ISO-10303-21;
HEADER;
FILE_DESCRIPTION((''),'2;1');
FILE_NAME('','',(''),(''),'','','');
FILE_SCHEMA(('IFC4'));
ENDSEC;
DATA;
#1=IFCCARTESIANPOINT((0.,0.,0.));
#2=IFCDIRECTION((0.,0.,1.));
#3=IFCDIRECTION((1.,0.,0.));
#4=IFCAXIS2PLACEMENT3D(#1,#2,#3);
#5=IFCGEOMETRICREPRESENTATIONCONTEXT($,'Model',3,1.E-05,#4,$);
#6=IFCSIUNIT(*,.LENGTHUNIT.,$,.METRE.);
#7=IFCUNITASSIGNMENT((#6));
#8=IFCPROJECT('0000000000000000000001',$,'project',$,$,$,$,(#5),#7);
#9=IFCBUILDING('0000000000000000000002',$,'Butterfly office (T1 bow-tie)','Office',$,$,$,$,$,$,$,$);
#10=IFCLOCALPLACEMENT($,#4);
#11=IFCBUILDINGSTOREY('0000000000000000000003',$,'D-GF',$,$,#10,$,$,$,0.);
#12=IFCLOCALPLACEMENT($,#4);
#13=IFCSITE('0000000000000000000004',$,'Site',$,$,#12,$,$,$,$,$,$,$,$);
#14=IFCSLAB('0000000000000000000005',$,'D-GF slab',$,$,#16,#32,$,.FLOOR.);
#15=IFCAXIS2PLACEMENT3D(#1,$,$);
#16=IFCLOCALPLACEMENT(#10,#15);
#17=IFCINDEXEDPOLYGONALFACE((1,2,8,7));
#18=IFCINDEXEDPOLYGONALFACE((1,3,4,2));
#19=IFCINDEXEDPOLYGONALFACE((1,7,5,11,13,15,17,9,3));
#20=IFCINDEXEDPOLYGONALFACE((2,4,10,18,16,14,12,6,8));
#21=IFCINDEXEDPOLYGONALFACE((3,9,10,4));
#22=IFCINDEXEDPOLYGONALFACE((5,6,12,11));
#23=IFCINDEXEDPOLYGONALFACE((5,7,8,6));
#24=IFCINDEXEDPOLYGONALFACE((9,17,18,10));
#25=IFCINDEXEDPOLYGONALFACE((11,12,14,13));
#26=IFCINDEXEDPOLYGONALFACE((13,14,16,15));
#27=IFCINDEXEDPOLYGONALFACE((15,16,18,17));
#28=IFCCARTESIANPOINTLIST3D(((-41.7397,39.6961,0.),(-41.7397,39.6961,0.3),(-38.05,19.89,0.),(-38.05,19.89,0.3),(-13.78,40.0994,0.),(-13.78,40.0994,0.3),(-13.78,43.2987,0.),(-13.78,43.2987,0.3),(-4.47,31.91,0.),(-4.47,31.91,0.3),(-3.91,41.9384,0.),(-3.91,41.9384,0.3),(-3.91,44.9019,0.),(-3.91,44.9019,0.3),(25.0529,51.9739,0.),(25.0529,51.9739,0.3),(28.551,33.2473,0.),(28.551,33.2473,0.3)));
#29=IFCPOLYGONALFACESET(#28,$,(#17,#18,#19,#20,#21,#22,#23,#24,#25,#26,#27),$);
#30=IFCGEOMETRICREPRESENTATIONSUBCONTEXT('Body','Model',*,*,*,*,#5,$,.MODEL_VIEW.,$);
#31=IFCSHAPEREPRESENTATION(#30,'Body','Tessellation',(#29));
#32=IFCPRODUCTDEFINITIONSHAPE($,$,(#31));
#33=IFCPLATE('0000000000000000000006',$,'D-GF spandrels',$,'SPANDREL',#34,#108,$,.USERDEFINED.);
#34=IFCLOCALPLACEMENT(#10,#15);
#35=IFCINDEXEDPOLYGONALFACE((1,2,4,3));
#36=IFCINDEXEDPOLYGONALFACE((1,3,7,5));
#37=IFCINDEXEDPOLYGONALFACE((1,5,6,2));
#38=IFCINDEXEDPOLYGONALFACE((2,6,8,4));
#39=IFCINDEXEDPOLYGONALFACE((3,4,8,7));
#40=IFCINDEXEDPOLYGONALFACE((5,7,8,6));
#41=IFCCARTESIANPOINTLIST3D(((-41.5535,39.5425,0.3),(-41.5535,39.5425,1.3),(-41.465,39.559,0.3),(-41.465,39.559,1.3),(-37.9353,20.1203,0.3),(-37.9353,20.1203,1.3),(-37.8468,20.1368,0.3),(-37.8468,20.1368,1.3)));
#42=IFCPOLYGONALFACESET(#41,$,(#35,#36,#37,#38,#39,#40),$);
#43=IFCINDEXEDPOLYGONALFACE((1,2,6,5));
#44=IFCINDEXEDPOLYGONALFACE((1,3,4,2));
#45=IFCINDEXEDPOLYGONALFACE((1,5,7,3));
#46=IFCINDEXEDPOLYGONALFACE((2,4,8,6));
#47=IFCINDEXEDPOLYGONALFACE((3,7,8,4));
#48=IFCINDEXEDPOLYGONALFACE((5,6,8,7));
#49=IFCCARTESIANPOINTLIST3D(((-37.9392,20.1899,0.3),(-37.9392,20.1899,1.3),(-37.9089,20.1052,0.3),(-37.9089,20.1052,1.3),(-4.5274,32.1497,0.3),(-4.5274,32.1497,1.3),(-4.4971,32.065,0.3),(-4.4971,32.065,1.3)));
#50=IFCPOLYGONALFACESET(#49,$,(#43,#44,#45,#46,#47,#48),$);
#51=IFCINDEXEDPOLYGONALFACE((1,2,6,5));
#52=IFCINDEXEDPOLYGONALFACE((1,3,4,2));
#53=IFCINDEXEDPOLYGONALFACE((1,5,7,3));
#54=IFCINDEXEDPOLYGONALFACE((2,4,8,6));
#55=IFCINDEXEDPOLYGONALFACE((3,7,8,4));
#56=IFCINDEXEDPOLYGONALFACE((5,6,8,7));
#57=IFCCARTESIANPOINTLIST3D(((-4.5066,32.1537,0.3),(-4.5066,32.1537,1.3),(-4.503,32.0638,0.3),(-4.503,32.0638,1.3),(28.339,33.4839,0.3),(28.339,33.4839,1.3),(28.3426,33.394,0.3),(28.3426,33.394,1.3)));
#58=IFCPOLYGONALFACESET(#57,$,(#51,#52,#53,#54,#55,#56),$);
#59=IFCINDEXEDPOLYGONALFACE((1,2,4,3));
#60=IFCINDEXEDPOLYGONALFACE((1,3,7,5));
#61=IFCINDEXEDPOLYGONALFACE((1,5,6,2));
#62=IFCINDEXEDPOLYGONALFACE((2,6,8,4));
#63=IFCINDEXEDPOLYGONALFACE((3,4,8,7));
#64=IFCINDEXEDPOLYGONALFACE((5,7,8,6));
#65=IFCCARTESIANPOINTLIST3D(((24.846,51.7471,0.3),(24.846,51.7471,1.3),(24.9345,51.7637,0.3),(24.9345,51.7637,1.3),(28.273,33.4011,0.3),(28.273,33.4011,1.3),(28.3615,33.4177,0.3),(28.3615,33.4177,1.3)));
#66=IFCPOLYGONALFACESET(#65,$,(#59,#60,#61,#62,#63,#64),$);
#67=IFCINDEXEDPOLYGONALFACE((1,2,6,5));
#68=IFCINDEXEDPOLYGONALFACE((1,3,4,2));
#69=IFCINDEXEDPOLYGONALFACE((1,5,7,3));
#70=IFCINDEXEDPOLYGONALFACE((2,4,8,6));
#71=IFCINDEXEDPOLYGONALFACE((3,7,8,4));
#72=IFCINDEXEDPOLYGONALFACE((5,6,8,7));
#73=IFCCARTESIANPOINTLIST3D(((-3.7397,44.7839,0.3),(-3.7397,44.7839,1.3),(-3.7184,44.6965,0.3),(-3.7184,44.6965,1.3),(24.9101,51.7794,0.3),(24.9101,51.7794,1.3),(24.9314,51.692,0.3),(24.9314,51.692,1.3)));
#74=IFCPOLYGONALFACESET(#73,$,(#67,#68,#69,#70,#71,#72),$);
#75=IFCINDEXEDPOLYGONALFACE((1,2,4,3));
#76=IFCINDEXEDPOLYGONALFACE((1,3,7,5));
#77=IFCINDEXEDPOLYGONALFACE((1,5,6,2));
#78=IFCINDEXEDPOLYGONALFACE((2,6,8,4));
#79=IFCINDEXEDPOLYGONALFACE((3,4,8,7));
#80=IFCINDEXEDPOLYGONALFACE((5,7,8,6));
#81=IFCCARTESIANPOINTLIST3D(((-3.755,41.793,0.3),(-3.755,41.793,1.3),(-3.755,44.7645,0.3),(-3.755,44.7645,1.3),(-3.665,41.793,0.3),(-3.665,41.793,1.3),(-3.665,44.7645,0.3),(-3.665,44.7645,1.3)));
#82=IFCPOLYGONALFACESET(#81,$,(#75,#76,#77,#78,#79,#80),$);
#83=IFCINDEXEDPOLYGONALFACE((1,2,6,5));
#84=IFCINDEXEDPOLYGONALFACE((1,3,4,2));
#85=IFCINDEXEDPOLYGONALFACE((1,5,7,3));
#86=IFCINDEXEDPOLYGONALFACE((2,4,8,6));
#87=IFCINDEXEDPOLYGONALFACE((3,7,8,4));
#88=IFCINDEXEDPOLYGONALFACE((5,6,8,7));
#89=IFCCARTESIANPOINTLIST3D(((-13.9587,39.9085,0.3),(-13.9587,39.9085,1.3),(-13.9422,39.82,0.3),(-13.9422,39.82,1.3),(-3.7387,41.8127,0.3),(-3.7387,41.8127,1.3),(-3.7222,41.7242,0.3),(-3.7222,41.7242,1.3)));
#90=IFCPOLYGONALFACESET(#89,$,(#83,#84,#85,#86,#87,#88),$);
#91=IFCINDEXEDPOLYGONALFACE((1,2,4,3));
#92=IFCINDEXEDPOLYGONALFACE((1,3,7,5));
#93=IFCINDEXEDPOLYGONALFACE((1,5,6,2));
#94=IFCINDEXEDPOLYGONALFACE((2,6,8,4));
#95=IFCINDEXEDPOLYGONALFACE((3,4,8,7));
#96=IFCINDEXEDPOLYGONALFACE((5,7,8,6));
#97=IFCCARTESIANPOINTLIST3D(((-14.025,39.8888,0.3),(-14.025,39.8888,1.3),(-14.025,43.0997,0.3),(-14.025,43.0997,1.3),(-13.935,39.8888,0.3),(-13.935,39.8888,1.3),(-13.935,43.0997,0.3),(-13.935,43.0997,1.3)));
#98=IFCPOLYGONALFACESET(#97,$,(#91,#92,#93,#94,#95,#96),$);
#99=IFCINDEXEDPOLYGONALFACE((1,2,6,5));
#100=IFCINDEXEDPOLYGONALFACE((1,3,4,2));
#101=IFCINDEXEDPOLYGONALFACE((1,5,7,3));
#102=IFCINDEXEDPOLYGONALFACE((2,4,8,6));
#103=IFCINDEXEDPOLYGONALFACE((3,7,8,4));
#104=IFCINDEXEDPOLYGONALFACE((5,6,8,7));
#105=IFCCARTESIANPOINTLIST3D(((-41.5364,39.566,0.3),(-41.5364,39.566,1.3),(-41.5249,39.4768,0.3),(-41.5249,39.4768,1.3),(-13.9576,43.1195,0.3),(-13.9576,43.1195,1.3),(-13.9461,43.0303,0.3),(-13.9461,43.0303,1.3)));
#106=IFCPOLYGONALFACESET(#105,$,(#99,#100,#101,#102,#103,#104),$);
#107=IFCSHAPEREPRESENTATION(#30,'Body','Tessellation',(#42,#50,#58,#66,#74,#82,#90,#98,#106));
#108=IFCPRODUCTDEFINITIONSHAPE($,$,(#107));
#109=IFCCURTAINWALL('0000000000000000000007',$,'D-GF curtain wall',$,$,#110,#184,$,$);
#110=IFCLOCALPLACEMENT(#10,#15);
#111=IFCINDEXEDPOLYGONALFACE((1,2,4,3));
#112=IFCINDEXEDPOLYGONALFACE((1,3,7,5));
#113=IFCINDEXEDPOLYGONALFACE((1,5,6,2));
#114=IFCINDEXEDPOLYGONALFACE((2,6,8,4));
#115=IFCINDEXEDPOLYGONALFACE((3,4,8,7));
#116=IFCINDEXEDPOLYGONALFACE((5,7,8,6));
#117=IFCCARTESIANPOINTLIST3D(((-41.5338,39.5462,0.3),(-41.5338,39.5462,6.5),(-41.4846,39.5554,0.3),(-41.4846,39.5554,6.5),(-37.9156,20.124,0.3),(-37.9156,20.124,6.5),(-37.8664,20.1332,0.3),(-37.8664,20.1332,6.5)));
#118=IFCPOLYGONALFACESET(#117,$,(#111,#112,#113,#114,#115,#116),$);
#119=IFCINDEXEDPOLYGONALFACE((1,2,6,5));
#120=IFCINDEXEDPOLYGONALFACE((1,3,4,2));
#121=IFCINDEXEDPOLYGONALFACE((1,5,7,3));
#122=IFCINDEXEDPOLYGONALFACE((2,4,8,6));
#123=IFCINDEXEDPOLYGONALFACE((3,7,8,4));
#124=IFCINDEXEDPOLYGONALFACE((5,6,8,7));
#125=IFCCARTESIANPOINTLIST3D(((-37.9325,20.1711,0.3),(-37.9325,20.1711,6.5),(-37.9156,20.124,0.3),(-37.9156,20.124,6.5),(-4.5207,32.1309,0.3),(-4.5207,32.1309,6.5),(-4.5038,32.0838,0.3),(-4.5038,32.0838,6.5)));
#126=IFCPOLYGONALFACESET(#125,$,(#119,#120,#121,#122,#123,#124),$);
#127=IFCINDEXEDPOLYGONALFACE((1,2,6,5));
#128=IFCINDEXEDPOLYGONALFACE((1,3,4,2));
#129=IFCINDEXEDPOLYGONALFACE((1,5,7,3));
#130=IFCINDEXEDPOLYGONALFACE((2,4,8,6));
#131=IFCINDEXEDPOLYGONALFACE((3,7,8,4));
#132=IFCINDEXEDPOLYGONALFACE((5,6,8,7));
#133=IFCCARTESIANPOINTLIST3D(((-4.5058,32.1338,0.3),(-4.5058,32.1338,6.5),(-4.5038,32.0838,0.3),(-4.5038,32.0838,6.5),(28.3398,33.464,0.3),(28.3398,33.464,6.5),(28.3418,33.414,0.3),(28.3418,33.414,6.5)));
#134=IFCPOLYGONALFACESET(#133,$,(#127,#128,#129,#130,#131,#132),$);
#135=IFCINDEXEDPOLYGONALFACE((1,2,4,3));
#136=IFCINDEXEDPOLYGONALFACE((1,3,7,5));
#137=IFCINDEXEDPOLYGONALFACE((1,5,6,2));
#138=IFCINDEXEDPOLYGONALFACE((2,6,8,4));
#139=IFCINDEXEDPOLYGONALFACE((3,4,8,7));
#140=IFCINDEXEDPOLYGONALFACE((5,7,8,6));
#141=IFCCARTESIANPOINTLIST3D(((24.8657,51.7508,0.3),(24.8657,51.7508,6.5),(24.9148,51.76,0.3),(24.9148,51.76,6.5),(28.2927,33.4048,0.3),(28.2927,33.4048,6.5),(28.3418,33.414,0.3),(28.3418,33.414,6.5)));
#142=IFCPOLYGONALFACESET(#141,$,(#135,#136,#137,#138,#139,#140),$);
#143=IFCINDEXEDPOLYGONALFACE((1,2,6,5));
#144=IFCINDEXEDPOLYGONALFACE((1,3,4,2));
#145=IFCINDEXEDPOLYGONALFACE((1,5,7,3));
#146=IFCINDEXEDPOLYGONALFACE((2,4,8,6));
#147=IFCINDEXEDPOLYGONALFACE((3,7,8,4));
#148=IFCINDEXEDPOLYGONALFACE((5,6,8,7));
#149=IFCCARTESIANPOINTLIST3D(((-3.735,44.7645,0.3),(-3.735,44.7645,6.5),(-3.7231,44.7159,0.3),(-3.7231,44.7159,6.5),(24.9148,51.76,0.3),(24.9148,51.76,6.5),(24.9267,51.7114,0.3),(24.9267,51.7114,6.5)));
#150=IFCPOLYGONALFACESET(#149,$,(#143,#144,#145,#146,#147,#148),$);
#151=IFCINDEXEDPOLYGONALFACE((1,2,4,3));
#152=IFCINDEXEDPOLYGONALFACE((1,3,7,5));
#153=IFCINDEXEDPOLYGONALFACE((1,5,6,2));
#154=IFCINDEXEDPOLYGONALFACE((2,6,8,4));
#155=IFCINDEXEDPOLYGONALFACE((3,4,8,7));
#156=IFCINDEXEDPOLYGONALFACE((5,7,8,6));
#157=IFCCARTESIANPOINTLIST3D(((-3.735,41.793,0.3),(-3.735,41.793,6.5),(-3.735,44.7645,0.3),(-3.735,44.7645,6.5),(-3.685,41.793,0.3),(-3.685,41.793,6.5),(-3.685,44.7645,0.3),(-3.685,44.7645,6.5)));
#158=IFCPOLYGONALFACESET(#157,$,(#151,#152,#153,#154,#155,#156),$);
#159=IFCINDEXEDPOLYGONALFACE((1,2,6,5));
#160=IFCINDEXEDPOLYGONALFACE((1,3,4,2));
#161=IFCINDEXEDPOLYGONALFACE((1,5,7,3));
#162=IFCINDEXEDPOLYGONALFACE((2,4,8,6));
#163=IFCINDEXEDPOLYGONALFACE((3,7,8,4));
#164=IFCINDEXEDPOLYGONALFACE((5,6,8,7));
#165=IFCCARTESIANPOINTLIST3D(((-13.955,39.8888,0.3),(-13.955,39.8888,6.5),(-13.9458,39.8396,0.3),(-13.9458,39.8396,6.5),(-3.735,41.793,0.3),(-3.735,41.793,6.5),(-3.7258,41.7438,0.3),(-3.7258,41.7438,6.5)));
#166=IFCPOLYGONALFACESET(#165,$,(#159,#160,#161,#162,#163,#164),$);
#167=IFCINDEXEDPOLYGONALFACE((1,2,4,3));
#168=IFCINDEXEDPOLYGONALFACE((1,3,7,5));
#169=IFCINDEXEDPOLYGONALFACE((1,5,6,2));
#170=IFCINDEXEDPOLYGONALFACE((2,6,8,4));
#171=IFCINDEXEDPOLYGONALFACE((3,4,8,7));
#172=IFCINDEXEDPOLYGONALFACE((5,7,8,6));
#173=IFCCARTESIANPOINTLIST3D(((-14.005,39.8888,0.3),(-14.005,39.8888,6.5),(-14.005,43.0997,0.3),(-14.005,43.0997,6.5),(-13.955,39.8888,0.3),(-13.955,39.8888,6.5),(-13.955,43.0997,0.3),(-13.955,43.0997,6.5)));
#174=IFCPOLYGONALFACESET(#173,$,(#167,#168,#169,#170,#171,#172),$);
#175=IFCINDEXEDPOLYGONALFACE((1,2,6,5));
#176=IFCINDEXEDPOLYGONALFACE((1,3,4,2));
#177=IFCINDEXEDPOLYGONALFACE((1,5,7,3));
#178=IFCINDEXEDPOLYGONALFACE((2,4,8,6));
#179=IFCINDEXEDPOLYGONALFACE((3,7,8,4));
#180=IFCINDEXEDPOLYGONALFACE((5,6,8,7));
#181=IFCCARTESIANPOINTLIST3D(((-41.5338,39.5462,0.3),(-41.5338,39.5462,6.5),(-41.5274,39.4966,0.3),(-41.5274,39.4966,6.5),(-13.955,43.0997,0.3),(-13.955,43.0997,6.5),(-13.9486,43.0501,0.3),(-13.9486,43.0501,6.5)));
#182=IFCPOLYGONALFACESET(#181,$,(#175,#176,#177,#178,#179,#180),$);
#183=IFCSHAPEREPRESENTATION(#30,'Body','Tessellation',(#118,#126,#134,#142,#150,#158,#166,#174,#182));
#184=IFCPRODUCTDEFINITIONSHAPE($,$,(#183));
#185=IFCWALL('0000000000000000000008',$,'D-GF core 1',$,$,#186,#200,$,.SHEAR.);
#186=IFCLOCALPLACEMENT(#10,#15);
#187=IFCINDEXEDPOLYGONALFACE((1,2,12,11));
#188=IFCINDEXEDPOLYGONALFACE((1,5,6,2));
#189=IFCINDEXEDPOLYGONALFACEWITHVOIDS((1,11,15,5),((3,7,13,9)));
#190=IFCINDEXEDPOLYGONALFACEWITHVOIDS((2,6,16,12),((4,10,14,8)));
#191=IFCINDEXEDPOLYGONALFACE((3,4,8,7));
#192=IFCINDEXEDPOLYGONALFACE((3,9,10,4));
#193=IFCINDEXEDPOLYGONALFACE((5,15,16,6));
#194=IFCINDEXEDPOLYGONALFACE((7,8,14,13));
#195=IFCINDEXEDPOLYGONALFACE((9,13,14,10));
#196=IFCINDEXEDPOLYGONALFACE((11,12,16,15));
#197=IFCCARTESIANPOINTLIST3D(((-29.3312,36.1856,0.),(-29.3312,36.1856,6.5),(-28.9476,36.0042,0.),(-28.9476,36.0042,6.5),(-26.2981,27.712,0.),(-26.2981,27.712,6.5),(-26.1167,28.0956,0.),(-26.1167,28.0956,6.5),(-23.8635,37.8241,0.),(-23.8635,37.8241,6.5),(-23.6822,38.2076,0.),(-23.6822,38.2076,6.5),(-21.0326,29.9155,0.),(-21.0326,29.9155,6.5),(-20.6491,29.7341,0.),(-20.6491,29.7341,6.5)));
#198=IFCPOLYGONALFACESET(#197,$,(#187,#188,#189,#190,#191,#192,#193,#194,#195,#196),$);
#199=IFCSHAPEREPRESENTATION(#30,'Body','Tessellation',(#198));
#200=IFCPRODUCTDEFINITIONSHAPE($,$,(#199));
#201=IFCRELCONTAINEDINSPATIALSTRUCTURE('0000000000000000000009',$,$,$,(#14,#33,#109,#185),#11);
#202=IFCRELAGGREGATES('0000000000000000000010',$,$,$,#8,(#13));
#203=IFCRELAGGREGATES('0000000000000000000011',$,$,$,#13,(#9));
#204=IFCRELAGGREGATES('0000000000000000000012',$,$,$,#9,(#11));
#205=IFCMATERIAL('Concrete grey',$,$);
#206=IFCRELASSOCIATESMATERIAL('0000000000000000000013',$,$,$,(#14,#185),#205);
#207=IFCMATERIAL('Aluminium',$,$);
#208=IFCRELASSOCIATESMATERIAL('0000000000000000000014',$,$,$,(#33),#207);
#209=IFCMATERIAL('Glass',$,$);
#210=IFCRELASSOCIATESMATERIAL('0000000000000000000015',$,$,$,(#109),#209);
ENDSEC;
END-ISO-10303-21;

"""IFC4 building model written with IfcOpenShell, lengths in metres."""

from ifc_helpers import new_model, si_unit, frame, origin_with_axes, place, context, subcontext, project, spatial, polyline, outline, extrude, material, element, save


model = new_model("IFC4")

# Units and contexts
model_context = context("Model", 3, precision=1e-05, world=origin_with_axes())
body_context = subcontext(model_context, "Body", "Model", "MODEL_VIEW")
ifc_project = project(units=[si_unit("LENGTHUNIT", "METRE")], contexts=[model_context])

# Site, building, storey
site_placement = place(None, origin_with_axes())
site = spatial("IfcSite", under=ifc_project, at=site_placement, Name="Site")
building = spatial("IfcBuilding", under=site, Name="Butterfly office (T1 bow-tie)", Description="Office")
storey_placement = place(None, origin_with_axes())
storey = spatial("IfcBuildingStorey", under=building, at=storey_placement, Name="D-GF", Elevation=0.0)

# Shared definitions
ifc_material_1 = material(Name="Aluminium")

# Slab
ifc_material_2 = material(Name="Concrete grey")
slab_placement = place(storey_placement, origin_with_axes())
element("IfcSlab", 1, at=slab_placement, inside=storey, material=ifc_material_2, Name="D-GF slab", PredefinedType="FLOOR", context=body_context, shape_type="SweptSolid", body=[
    extrude(outline(polyline([(-41.7397, 39.6961), (-38.05, 19.89), (-4.47, 31.91), (28.551, 33.2473), (25.0529, 51.9739), (-3.91, 44.9019), (-3.91, 41.9384), (-13.78, 40.0994), (-13.78, 43.2987), (-41.7397, 39.6961)])), origin_with_axes(), (0.0, 0.0, 1.0), 0.3),
])

# Plate
plate_placement = place(storey_placement, origin_with_axes())
element("IfcPlate", 2, at=plate_placement, inside=storey, material=ifc_material_1, Name="D-GF spandrels", ObjectType="SPANDREL", PredefinedType="USERDEFINED", context=body_context, shape_type="SweptSolid", body=[
    extrude(outline(polyline([(-41.5535, 39.5425), (-37.9353, 20.1203), (-37.8468, 20.1368), (-41.465, 39.559), (-41.5535, 39.5425)])), frame((0.0, 0.0, 0.3), z_axis=(0.0, 0.0, 1.0), x_axis=(1.0, 0.0, 0.0)), (0.0, 0.0, 1.0), 1.0),
    extrude(outline(polyline([(-37.9089, 20.1052), (-4.4971, 32.065), (-4.5274, 32.1497), (-37.9392, 20.1899), (-37.9089, 20.1052)])), frame((0.0, 0.0, 0.3), z_axis=(0.0, 0.0, 1.0), x_axis=(1.0, 0.0, 0.0)), (0.0, 0.0, 1.0), 1.0),
    extrude(outline(polyline([(-4.503, 32.0638), (28.3426, 33.394), (28.339, 33.4839), (-4.5066, 32.1537), (-4.503, 32.0638)])), frame((0.0, 0.0, 0.3), z_axis=(0.0, 0.0, 1.0), x_axis=(1.0, 0.0, 0.0)), (0.0, 0.0, 1.0), 1.0),
    extrude(outline(polyline([(28.3615, 33.4177), (24.9345, 51.7637), (24.846, 51.7471), (28.273, 33.4011), (28.3615, 33.4177)])), frame((0.0, 0.0, 0.3), z_axis=(0.0, 0.0, 1.0), x_axis=(1.0, 0.0, 0.0)), (0.0, 0.0, 1.0), 1.0),
    extrude(outline(polyline([(24.9101, 51.7794), (-3.7397, 44.7839), (-3.7184, 44.6965), (24.9314, 51.692), (24.9101, 51.7794)])), frame((0.0, 0.0, 0.3), z_axis=(0.0, 0.0, 1.0), x_axis=(1.0, 0.0, 0.0)), (0.0, 0.0, 1.0), 1.0),
    extrude(outline(polyline([(-3.755, 44.7645), (-3.755, 41.793), (-3.665, 41.793), (-3.665, 44.7645), (-3.755, 44.7645)])), frame((0.0, 0.0, 0.3), z_axis=(0.0, 0.0, 1.0), x_axis=(1.0, 0.0, 0.0)), (0.0, 0.0, 1.0), 1.0),
    extrude(outline(polyline([(-3.7387, 41.8127), (-13.9587, 39.9085), (-13.9422, 39.82), (-3.7222, 41.7242), (-3.7387, 41.8127)])), frame((0.0, 0.0, 0.3), z_axis=(0.0, 0.0, 1.0), x_axis=(1.0, 0.0, 0.0)), (0.0, 0.0, 1.0), 1.0),
    extrude(outline(polyline([(-13.935, 39.8888), (-13.935, 43.0997), (-14.025, 43.0997), (-14.025, 39.8888), (-13.935, 39.8888)])), frame((0.0, 0.0, 0.3), z_axis=(0.0, 0.0, 1.0), x_axis=(1.0, 0.0, 0.0)), (0.0, 0.0, 1.0), 1.0),
    extrude(outline(polyline([(-13.9576, 43.1195), (-41.5364, 39.566), (-41.5249, 39.4768), (-13.9461, 43.0303), (-13.9576, 43.1195)])), frame((0.0, 0.0, 0.3), z_axis=(0.0, 0.0, 1.0), x_axis=(1.0, 0.0, 0.0)), (0.0, 0.0, 1.0), 1.0),
])

# Curtain wall
ifc_material_3 = material(Name="Glass")
curtain_wall_placement = place(storey_placement, origin_with_axes())
element("IfcCurtainWall", 3, at=curtain_wall_placement, inside=storey, material=ifc_material_3, Name="D-GF curtain wall", context=body_context, shape_type="SweptSolid", body=[
    extrude(outline(polyline([(-41.5338, 39.5462), (-37.9156, 20.124), (-37.8664, 20.1332), (-41.4846, 39.5554), (-41.5338, 39.5462)])), frame((0.0, 0.0, 0.3), z_axis=(0.0, 0.0, 1.0), x_axis=(1.0, 0.0, 0.0)), (0.0, 0.0, 1.0), 6.2),
    extrude(outline(polyline([(-37.9156, 20.124), (-4.5038, 32.0838), (-4.5207, 32.1309), (-37.9325, 20.1711), (-37.9156, 20.124)])), frame((0.0, 0.0, 0.3), z_axis=(0.0, 0.0, 1.0), x_axis=(1.0, 0.0, 0.0)), (0.0, 0.0, 1.0), 6.2),
    extrude(outline(polyline([(-4.5038, 32.0838), (28.3418, 33.414), (28.3398, 33.464), (-4.5058, 32.1338), (-4.5038, 32.0838)])), frame((0.0, 0.0, 0.3), z_axis=(0.0, 0.0, 1.0), x_axis=(1.0, 0.0, 0.0)), (0.0, 0.0, 1.0), 6.2),
    extrude(outline(polyline([(28.3418, 33.414), (24.9148, 51.76), (24.8657, 51.7508), (28.2927, 33.4048), (28.3418, 33.414)])), frame((0.0, 0.0, 0.3), z_axis=(0.0, 0.0, 1.0), x_axis=(1.0, 0.0, 0.0)), (0.0, 0.0, 1.0), 6.2),
    extrude(outline(polyline([(24.9148, 51.76), (-3.735, 44.7645), (-3.7231, 44.7159), (24.9267, 51.7114), (24.9148, 51.76)])), frame((0.0, 0.0, 0.3), z_axis=(0.0, 0.0, 1.0), x_axis=(1.0, 0.0, 0.0)), (0.0, 0.0, 1.0), 6.2),
    extrude(outline(polyline([(-3.735, 44.7645), (-3.735, 41.793), (-3.685, 41.793), (-3.685, 44.7645), (-3.735, 44.7645)])), frame((0.0, 0.0, 0.3), z_axis=(0.0, 0.0, 1.0), x_axis=(1.0, 0.0, 0.0)), (0.0, 0.0, 1.0), 6.2),
    extrude(outline(polyline([(-3.735, 41.793), (-13.955, 39.8888), (-13.9458, 39.8396), (-3.7258, 41.7438), (-3.735, 41.793)])), frame((0.0, 0.0, 0.3), z_axis=(0.0, 0.0, 1.0), x_axis=(1.0, 0.0, 0.0)), (0.0, 0.0, 1.0), 6.2),
    extrude(outline(polyline([(-13.955, 39.8888), (-13.955, 43.0997), (-14.005, 43.0997), (-14.005, 39.8888), (-13.955, 39.8888)])), frame((0.0, 0.0, 0.3), z_axis=(0.0, 0.0, 1.0), x_axis=(1.0, 0.0, 0.0)), (0.0, 0.0, 1.0), 6.2),
    extrude(outline(polyline([(-13.955, 43.0997), (-41.5338, 39.5462), (-41.5274, 39.4966), (-13.9486, 43.0501), (-13.955, 43.0997)])), frame((0.0, 0.0, 0.3), z_axis=(0.0, 0.0, 1.0), x_axis=(1.0, 0.0, 0.0)), (0.0, 0.0, 1.0), 6.2),
])

# Wall
wall_1_placement = place(storey_placement, origin_with_axes())
element("IfcWall", 4, at=wall_1_placement, inside=storey, material=ifc_material_2, Name="D-GF core 1", PredefinedType="SHEAR", context=body_context, shape_type="SweptSolid", body=[
    extrude(outline(polyline([(-26.2981, 27.712), (-20.6491, 29.7341), (-23.6822, 38.2076), (-29.3312, 36.1856), (-26.2981, 27.712)]), holes=[polyline([(-26.1167, 28.0956), (-21.0326, 29.9155), (-23.8635, 37.8241), (-28.9476, 36.0042), (-26.1167, 28.0956)])]), origin_with_axes(), (0.0, 0.0, 1.0), 6.5),
])

save(model, "model.ifc")
